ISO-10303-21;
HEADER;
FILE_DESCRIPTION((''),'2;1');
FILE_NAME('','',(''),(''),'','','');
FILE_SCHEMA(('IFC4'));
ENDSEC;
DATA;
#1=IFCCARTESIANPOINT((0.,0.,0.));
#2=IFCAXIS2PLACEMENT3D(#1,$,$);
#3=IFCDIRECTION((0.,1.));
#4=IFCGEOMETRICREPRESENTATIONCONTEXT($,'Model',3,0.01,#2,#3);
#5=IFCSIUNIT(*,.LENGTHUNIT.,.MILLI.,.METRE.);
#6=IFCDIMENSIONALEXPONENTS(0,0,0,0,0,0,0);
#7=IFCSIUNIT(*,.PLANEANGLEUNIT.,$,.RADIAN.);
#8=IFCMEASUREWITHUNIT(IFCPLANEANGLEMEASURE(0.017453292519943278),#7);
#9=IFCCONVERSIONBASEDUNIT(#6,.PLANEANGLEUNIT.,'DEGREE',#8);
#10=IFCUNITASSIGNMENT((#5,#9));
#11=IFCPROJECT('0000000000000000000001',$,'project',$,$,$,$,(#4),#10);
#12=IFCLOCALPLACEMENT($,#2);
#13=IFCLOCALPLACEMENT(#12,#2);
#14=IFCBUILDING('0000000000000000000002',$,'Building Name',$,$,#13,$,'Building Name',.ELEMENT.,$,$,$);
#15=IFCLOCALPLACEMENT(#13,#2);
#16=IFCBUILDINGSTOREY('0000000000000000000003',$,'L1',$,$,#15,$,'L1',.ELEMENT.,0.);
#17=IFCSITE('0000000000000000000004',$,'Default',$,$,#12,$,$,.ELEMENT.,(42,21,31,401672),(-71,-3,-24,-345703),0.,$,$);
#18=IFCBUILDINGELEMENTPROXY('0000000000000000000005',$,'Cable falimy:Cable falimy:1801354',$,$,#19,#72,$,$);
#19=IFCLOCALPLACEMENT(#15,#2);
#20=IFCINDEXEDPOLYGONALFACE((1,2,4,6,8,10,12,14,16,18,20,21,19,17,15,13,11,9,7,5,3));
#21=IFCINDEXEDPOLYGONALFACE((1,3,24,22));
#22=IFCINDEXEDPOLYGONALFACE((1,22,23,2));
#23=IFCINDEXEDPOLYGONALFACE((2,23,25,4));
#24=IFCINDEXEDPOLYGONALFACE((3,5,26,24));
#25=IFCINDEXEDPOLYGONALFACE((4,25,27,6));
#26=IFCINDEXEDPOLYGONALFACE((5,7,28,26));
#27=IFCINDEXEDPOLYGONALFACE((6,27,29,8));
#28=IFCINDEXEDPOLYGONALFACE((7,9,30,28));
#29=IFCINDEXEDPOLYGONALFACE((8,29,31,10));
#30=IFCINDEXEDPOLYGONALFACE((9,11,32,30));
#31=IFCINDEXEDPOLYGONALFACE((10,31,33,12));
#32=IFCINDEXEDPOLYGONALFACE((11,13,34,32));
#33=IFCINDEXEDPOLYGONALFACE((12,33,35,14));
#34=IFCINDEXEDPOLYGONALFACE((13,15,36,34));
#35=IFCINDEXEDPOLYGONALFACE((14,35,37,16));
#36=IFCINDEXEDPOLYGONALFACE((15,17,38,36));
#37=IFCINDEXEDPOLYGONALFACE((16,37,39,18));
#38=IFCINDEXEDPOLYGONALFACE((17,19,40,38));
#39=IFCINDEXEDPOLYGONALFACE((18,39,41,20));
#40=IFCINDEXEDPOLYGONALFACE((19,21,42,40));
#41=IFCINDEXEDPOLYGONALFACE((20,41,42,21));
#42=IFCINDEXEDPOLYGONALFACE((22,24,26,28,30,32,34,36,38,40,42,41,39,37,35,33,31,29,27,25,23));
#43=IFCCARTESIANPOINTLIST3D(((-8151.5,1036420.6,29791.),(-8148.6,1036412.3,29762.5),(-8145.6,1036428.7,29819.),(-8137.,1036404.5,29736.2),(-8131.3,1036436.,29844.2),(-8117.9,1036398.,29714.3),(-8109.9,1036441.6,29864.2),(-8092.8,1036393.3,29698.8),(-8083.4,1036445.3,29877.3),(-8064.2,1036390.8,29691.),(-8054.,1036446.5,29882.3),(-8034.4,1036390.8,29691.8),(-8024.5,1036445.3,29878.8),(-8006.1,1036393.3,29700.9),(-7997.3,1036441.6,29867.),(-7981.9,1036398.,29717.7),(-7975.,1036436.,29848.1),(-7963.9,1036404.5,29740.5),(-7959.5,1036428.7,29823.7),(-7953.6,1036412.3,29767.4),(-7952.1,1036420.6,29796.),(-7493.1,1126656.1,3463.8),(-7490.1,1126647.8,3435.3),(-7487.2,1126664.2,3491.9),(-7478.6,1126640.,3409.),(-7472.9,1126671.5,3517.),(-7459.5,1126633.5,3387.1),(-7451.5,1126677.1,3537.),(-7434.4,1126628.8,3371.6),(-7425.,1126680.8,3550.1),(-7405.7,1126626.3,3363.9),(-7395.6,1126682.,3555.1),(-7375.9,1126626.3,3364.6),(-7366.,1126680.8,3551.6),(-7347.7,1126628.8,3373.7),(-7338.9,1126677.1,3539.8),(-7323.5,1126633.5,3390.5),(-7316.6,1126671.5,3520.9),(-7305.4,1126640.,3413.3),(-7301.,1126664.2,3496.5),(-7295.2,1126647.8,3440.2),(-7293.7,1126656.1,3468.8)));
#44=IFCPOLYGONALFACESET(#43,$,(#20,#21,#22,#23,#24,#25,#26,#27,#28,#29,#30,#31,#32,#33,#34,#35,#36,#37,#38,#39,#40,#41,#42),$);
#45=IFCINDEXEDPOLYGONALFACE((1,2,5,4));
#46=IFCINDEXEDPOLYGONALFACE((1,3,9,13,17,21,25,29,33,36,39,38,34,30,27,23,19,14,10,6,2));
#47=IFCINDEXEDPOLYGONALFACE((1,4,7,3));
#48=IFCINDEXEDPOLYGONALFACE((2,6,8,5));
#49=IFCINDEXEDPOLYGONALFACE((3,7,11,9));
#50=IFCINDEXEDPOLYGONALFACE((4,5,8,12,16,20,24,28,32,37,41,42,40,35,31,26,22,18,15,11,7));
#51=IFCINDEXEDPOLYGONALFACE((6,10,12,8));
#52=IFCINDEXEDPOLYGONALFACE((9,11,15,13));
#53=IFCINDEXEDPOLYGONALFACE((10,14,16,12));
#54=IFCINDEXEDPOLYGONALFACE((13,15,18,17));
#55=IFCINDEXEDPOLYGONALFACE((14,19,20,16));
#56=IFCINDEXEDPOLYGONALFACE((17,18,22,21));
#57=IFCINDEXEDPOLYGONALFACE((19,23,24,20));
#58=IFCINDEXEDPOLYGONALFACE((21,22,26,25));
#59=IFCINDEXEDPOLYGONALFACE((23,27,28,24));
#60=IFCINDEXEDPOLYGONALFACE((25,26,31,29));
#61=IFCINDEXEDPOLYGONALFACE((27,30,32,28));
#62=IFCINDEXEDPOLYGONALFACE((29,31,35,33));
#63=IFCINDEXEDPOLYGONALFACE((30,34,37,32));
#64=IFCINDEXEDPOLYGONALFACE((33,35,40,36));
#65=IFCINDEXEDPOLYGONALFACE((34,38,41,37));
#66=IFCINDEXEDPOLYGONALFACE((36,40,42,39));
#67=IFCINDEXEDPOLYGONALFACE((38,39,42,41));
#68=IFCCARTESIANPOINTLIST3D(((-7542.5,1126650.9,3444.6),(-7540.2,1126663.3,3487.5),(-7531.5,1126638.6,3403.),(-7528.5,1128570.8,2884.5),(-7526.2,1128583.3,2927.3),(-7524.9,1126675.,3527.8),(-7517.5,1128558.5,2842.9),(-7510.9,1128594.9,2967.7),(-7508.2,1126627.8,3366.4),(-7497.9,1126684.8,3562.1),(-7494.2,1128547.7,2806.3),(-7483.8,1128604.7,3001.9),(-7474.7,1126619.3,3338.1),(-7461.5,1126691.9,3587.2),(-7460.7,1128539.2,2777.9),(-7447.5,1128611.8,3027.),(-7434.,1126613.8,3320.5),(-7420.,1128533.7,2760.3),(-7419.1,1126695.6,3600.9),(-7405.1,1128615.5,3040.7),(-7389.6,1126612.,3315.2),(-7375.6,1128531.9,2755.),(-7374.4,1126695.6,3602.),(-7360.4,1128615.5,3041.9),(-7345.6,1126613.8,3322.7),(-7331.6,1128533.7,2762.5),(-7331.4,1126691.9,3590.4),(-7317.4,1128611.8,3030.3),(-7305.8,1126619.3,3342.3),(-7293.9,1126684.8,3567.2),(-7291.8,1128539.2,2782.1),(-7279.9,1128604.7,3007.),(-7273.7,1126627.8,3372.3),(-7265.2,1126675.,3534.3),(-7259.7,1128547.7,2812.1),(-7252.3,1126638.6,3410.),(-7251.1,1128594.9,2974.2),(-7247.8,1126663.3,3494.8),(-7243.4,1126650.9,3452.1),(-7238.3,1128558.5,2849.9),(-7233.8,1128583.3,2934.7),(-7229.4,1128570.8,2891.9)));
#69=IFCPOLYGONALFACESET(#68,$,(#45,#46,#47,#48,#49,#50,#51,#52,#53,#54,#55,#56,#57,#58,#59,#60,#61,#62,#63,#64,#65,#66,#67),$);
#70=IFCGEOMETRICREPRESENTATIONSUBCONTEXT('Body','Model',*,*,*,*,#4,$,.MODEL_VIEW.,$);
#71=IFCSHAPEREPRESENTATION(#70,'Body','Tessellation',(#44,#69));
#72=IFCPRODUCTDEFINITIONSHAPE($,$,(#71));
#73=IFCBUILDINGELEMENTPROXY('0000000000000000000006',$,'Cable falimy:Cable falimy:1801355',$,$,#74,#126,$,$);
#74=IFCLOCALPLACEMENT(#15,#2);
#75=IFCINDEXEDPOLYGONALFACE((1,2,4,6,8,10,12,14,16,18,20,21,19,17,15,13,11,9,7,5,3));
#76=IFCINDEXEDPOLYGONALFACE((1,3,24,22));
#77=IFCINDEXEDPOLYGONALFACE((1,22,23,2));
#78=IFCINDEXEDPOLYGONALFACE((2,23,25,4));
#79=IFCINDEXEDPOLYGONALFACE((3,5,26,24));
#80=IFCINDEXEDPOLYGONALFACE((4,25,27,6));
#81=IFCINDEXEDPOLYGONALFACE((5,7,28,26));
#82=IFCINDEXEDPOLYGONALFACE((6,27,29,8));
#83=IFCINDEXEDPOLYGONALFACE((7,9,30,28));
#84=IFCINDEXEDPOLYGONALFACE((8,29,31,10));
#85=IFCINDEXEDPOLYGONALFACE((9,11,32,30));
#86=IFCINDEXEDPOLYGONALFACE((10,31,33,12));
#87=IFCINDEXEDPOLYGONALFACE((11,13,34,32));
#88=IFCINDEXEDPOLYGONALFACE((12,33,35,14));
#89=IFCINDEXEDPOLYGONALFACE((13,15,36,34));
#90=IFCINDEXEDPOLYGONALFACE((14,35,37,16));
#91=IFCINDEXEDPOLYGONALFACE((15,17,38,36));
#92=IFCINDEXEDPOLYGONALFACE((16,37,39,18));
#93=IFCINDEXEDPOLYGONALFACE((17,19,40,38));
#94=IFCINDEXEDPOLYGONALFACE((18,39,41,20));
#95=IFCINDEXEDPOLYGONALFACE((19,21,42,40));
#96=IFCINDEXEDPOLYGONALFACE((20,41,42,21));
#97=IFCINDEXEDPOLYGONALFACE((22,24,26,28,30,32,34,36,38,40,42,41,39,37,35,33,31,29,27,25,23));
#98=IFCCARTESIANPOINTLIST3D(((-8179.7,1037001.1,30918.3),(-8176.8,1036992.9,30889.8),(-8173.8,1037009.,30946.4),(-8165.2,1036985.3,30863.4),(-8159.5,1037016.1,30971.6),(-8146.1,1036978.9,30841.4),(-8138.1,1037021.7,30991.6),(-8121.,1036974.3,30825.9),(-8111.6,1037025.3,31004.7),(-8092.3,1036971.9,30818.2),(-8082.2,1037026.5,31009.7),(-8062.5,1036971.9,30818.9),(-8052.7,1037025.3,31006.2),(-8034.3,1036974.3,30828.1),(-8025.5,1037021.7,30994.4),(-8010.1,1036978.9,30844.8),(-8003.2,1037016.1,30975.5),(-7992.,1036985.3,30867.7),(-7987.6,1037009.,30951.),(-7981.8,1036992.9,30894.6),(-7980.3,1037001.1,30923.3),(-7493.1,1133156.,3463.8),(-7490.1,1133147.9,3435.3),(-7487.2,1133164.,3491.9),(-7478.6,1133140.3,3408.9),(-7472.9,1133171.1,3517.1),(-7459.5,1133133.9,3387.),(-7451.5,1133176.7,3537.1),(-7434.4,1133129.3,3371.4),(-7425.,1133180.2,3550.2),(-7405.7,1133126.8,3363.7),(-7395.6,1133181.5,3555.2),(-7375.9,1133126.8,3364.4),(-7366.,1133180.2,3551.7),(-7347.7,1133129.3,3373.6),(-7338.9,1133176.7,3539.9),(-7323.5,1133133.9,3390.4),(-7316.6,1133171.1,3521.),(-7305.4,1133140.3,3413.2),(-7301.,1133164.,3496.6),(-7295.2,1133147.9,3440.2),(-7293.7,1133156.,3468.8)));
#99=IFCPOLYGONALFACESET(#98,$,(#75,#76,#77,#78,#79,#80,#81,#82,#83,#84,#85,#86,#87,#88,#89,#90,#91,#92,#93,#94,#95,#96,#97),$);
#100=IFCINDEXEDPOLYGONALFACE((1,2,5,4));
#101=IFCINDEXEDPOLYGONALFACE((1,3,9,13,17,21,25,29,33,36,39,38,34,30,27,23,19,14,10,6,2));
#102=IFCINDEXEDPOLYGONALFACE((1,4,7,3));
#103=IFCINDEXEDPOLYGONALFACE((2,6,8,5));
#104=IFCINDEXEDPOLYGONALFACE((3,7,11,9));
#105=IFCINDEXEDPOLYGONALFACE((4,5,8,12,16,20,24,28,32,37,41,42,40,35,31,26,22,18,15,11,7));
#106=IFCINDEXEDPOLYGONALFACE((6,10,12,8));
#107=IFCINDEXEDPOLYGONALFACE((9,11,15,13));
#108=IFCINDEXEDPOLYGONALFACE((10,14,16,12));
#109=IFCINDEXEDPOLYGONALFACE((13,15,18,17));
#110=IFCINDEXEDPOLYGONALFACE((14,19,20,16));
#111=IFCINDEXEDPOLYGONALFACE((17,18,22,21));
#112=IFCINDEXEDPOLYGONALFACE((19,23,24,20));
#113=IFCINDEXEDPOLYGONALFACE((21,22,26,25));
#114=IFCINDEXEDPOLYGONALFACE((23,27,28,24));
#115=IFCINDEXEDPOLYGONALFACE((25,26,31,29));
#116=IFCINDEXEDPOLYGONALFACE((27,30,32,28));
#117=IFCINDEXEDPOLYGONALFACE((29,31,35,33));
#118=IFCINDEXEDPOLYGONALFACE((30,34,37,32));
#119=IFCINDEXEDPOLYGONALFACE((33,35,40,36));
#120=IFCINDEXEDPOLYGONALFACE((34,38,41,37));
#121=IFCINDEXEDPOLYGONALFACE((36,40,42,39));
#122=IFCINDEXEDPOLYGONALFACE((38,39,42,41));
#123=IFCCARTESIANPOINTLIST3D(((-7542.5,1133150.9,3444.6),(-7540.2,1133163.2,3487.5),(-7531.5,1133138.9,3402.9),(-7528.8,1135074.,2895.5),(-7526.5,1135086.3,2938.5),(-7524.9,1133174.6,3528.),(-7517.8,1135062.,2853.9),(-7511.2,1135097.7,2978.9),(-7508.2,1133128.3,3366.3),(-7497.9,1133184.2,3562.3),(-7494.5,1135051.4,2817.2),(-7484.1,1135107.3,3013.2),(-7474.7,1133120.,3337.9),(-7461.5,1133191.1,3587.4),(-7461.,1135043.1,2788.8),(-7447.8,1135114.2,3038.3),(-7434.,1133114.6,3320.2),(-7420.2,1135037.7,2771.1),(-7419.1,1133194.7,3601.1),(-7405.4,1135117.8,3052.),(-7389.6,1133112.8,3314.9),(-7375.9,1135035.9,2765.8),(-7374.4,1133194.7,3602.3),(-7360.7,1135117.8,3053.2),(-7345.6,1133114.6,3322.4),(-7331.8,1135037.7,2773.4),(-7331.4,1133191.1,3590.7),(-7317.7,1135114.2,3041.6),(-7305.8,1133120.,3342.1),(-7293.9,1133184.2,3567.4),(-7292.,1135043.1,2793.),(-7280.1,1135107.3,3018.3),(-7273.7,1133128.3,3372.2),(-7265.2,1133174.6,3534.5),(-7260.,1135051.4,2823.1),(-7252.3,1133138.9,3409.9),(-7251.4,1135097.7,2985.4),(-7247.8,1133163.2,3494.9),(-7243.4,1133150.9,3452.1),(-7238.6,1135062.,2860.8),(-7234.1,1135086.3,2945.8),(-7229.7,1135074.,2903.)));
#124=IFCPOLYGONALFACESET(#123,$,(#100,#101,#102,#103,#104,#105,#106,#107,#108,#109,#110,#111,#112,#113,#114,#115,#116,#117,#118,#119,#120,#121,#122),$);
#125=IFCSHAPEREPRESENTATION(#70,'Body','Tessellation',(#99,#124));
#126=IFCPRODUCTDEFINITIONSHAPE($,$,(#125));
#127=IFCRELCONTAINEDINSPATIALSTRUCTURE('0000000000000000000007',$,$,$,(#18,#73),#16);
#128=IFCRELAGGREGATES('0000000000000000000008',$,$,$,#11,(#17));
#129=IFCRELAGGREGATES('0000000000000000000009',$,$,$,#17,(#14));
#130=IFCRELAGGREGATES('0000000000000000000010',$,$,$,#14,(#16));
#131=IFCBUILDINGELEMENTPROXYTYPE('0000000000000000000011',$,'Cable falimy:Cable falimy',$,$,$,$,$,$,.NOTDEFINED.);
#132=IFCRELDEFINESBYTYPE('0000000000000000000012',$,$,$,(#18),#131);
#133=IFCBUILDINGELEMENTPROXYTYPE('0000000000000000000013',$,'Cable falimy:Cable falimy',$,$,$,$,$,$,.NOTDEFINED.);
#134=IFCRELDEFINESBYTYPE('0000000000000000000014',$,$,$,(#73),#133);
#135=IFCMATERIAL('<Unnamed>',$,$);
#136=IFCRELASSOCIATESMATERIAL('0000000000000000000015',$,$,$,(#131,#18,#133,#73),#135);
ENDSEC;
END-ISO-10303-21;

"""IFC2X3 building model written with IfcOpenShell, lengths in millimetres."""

from ifc_helpers import new_model, entity, si_unit, converted_unit, direction, frame, frame_2d, origin, place, context, subcontext, project, spatial, circle, extrude, source, transform, mapped, material, type_object, type_shapes, element, save


model = new_model("IFC2X3")

# Units and contexts
model_context = context("Model", 3, precision=0.01, world=origin(), true_north=direction((0.0, 1.0)))
body_context = subcontext(model_context, "Body", "Model", "MODEL_VIEW")
ifc_project = project(units=[si_unit("LENGTHUNIT", "METRE", prefix="MILLI"), converted_unit("PLANEANGLEUNIT", "DEGREE", entity("IfcPlaneAngleMeasure", 0.017453292519943278), si_unit("PLANEANGLEUNIT", "RADIAN"), dimensions=[0, 0, 0, 0, 0, 0, 0])], contexts=[model_context])

# Site, building, storey
site_placement = place(None, origin())
site = spatial("IfcSite", under=ifc_project, at=site_placement, Name="Default", CompositionType="ELEMENT", RefLatitude=(42, 21, 31, 401672), RefLongitude=(-71, -3, -24, -345703), RefElevation=0.0)
building_placement = place(site_placement, origin())
building = spatial("IfcBuilding", under=site, at=building_placement, Name="Building Name", LongName="Building Name", CompositionType="ELEMENT")
storey_placement = place(building_placement, origin())
storey = spatial("IfcBuildingStorey", under=building, at=storey_placement, Name="L1", LongName="L1", CompositionType="ELEMENT", Elevation=0.0)

# Shared definitions
ifc_material = material(Name="<Unnamed>")

# Building element proxies
building_element_proxy_type_1 = type_object("IfcBuildingElementProxyType", Name="Cable falimy:Cable falimy", PredefinedType="NOTDEFINED", material=ifc_material)
shared_shape_1 = source(origin(), body_context, "Body", "SweptSolid", [
    extrude(circle(Radius=100.0, at=frame_2d((0.0, 0.0), x_axis=(1.0, 0.0))), frame((0.0, 0.0, 0.0), z_axis=(0.959952, 0.0, 0.280164), x_axis=(-0.280164, 0.0, 0.959952)), (0.0, 0.0, 1.0), 94000.0),
    extrude(circle(Radius=150.0, at=frame_2d((0.0, 0.0), x_axis=(1.0, 0.0))), frame((-1919.9, 0.0, -560.3), z_axis=(0.959952, 0.0, 0.280164), x_axis=(0.280164, 0.0, -0.959952)), (0.0, 0.0, 1.0), 2000.0),
])
type_shapes(building_element_proxy_type_1, [shared_shape_1])
proxy_1_placement = place(storey_placement, frame((-7393.2, 1126654.0, 3459.1), z_axis=(-0.025001, 0.0, 0.999687), x_axis=(0.0, -1.0, 0.0)))
element("IfcBuildingElementProxy", 1, at=proxy_1_placement, inside=storey, type_object=building_element_proxy_type_1, material=ifc_material, Name="Cable falimy:Cable falimy:1801354", context=body_context, shape_type="MappedRepresentation", body=[
    mapped(shared_shape_1, transform((0.0, 0.0, 0.0), scale=1.0)),
])
building_element_proxy_type_2 = type_object("IfcBuildingElementProxyType", Name="Cable falimy:Cable falimy", PredefinedType="NOTDEFINED", material=ifc_material)
shared_shape_2 = source(origin(), body_context, "Body", "SweptSolid", [
    extrude(circle(Radius=100.0, at=frame_2d((0.0, 0.0), x_axis=(1.0, 0.0))), frame((0.0, 0.0, 0.0), z_axis=(0.96155, 0.0, 0.274631), x_axis=(-0.274631, 0.0, 0.96155)), (0.0, 0.0, 1.0), 100000.0),
    extrude(circle(Radius=150.0, at=frame_2d((0.0, 0.0), x_axis=(1.0, 0.0))), frame((-1923.1, 0.0, -549.3), z_axis=(0.96155, 0.0, 0.274631), x_axis=(0.274631, 0.0, -0.96155)), (0.0, 0.0, 1.0), 2000.0),
])
type_shapes(building_element_proxy_type_2, [shared_shape_2])
proxy_2_placement = place(storey_placement, frame((-7393.2, 1133154.0, 3459.1), z_axis=(-0.025001, 0.0, 0.999687), x_axis=(0.0, -1.0, 0.0)))
element("IfcBuildingElementProxy", 2, at=proxy_2_placement, inside=storey, type_object=building_element_proxy_type_2, material=ifc_material, Name="Cable falimy:Cable falimy:1801355", context=body_context, shape_type="MappedRepresentation", body=[
    mapped(shared_shape_2, transform((0.0, 0.0, 0.0), scale=1.0)),
])

save(model, "model.ifc")
